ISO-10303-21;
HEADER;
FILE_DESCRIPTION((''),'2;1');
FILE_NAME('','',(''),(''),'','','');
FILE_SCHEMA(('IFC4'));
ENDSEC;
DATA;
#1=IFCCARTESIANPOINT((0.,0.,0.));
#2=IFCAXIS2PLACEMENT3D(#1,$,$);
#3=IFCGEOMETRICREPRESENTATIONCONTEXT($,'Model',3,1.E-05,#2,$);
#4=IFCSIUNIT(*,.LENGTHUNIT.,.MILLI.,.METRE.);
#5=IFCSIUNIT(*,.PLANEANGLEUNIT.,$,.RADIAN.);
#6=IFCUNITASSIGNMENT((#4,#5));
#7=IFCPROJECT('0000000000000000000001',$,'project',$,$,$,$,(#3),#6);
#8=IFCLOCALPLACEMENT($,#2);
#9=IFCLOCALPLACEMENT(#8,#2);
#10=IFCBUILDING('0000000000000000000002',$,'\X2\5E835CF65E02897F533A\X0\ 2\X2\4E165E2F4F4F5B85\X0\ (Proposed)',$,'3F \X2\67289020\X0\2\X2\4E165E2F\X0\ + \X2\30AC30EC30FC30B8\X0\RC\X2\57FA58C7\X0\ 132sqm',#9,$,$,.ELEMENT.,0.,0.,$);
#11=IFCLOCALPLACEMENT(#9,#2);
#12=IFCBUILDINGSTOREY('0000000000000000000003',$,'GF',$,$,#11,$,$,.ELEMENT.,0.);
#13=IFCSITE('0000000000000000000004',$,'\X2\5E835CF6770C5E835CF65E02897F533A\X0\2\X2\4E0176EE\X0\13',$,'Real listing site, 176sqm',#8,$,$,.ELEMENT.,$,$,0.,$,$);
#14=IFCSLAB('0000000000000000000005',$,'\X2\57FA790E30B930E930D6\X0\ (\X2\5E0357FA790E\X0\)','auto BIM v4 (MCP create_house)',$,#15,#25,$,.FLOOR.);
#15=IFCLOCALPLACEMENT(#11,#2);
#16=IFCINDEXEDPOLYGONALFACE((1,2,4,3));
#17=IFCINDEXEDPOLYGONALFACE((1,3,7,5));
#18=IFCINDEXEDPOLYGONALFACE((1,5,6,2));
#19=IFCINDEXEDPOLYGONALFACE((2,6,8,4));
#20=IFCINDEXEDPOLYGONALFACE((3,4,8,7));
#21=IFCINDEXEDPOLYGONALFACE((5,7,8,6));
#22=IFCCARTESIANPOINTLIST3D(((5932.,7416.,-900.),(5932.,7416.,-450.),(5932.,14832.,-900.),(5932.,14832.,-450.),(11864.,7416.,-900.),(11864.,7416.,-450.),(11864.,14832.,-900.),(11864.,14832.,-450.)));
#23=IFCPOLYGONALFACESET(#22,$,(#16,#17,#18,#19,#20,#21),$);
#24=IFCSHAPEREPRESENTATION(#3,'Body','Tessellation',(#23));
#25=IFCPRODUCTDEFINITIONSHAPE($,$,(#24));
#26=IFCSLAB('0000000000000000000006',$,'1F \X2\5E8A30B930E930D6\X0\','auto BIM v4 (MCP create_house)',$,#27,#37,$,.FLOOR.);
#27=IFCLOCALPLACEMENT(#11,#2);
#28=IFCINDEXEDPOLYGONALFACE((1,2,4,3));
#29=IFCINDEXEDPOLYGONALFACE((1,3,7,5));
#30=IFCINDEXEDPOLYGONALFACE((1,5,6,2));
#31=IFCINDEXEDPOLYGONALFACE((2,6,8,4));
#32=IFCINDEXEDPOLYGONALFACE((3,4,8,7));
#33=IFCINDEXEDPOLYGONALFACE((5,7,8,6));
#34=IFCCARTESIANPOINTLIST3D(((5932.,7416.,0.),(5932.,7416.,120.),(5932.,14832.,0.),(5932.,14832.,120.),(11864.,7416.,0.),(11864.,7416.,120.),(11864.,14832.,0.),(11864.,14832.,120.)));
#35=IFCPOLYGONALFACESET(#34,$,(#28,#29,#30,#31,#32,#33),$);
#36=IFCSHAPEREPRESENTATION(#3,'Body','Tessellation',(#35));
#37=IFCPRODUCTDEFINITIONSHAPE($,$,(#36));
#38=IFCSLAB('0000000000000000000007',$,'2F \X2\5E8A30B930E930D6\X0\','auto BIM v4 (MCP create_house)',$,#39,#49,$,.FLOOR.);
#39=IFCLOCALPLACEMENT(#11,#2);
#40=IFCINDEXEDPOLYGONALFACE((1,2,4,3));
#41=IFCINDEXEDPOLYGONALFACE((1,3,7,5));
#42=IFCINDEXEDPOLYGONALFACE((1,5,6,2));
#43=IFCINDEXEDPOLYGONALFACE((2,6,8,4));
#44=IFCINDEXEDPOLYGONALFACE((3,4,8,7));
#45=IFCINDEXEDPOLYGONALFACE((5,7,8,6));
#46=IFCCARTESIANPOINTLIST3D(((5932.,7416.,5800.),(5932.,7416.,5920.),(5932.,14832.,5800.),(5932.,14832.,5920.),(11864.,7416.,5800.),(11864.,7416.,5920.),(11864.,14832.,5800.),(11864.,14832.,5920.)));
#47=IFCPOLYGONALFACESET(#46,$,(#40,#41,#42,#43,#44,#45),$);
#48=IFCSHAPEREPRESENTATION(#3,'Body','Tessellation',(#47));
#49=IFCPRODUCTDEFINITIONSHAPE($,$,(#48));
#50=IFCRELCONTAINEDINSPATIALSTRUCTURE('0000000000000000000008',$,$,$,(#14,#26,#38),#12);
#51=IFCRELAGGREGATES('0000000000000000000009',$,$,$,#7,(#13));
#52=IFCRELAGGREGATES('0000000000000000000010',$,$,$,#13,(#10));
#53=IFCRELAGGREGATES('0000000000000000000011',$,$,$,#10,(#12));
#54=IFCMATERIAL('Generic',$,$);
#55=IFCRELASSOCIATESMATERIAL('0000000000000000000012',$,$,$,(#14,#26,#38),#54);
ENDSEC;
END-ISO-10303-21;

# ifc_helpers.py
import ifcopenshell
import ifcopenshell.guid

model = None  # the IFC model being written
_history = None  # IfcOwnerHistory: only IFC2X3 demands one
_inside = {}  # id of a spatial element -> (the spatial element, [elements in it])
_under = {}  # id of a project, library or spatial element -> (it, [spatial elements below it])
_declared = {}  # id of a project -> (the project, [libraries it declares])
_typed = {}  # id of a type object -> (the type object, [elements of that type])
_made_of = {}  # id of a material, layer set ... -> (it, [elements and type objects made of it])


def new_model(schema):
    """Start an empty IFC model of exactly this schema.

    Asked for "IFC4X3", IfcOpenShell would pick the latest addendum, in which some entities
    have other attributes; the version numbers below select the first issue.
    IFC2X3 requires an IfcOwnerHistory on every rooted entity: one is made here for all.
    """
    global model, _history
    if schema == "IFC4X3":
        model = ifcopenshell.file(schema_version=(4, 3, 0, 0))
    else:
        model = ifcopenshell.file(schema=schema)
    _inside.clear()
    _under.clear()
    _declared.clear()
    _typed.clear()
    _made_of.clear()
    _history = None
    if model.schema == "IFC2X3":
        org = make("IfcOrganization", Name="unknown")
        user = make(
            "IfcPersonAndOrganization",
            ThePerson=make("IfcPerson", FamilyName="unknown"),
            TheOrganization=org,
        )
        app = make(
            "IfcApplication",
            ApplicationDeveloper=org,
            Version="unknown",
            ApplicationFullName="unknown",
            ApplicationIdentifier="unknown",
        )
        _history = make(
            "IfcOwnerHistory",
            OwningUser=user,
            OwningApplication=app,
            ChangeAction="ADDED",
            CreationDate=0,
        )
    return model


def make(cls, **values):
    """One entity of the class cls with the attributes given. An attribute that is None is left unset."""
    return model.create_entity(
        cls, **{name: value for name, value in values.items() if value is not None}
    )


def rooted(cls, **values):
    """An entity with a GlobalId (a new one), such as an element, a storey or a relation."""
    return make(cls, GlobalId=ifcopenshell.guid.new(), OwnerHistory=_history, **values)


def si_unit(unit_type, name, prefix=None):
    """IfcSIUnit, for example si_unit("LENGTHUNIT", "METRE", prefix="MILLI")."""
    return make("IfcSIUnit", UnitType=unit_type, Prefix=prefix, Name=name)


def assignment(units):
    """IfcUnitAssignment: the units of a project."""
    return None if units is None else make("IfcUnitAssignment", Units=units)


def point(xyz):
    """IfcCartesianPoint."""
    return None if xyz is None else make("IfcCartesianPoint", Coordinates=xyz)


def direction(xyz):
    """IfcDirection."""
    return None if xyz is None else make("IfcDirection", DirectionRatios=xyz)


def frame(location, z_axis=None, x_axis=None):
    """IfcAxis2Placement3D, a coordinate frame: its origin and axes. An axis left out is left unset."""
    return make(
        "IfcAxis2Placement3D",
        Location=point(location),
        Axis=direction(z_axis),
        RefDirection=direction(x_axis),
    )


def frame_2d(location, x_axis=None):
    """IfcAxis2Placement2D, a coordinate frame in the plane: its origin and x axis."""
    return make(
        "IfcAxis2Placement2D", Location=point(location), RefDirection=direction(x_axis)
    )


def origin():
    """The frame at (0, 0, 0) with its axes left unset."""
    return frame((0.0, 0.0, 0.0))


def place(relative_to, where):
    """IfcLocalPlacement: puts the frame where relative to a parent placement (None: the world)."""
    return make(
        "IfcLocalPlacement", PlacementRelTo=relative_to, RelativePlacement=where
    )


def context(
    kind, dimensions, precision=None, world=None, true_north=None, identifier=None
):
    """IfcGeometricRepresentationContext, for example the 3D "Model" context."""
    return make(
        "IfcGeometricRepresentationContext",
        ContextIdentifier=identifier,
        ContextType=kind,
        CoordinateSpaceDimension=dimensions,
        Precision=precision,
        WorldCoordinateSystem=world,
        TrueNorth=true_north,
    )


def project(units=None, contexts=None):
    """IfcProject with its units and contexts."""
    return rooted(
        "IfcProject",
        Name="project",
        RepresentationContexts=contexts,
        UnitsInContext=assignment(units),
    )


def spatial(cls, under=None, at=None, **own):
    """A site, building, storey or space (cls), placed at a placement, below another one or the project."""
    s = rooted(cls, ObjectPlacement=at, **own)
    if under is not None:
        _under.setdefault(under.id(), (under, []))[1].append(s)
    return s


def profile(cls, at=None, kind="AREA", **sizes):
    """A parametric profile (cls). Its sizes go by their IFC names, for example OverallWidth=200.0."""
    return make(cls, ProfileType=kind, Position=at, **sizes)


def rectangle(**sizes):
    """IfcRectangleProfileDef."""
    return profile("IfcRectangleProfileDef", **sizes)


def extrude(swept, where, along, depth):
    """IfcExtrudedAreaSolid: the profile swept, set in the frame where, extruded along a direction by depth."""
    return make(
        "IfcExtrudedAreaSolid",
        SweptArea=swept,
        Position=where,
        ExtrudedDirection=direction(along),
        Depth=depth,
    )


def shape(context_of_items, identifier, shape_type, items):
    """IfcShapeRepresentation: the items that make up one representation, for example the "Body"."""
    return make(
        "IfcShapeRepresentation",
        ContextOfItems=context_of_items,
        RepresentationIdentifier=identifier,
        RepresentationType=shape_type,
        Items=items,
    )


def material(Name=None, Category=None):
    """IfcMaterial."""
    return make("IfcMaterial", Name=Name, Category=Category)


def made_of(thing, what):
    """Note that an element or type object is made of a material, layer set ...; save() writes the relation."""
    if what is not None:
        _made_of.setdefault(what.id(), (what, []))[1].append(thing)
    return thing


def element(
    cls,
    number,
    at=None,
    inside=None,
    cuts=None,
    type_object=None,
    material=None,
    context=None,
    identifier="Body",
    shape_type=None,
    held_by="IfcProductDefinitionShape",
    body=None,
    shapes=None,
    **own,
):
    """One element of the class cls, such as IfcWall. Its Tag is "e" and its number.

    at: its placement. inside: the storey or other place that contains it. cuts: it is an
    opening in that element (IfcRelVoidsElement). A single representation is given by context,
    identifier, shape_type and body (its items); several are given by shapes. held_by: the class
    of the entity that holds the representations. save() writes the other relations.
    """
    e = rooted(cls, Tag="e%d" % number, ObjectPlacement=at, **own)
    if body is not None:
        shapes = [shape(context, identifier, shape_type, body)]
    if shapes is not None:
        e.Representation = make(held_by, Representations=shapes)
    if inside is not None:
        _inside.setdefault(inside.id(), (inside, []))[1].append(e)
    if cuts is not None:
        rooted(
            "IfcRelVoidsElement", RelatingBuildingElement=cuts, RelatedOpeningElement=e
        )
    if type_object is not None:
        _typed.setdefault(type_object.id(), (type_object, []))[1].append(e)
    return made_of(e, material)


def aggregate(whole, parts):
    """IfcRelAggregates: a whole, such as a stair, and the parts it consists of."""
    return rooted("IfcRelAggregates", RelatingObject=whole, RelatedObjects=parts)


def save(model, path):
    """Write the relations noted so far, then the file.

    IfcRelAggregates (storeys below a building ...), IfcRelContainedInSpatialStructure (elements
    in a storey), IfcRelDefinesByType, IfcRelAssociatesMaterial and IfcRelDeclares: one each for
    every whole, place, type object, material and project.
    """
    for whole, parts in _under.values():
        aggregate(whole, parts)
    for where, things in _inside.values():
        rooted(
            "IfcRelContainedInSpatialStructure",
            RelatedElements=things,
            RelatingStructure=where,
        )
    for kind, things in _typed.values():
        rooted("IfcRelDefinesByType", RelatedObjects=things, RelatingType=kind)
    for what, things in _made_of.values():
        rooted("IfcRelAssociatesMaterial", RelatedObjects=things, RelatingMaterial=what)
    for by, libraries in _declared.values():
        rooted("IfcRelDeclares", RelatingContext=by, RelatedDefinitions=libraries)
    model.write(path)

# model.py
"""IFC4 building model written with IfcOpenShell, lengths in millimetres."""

from ifc_helpers import new_model, si_unit, frame, frame_2d, origin, place, context, project, spatial, rectangle, extrude, material, element, save


model = new_model("IFC4")

# Units and contexts
model_context = context("Model", 3, precision=1e-05, world=origin())
ifc_project = project(units=[si_unit("LENGTHUNIT", "METRE", prefix="MILLI"), si_unit("PLANEANGLEUNIT", "RADIAN")], contexts=[model_context])

# Site, building, storey
site_placement = place(None, origin())
site = spatial("IfcSite", under=ifc_project, at=site_placement, Name="広島県広島市西区2丁目13", ObjectType="Real listing site, 176sqm", CompositionType="ELEMENT", RefElevation=0.0)
building_placement = place(site_placement, origin())
building = spatial("IfcBuilding", under=site, at=building_placement, Name="広島市西区 2世帯住宅 (Proposed)", ObjectType="3F 木造2世帯 + ガレージRC基壇 132sqm", CompositionType="ELEMENT", ElevationOfRefHeight=0.0, ElevationOfTerrain=0.0)
storey_placement = place(building_placement, origin())
storey = spatial("IfcBuildingStorey", under=building, at=storey_placement, Name="GF", CompositionType="ELEMENT", Elevation=0.0)

# Slabs
ifc_material = material(Name="Generic")
slab_1_placement = place(storey_placement, frame((2966.0, 3708.0, -450.0)))
element("IfcSlab", 1, at=slab_1_placement, inside=storey, material=ifc_material, Name="基礎スラブ (布基礎)", Description="auto BIM v4 (MCP create_house)", PredefinedType="FLOOR", context=model_context, shape_type="SweptSolid", body=[
    extrude(rectangle(XDim=5932.0, YDim=7416.0, at=frame_2d((2966.0, 3708.0))), frame((2966.0, 3708.0, -450.0)), (0.0, 0.0, 1.0), 450.0),
])
slab_2_placement = place(storey_placement, frame((2966.0, 3708.0, 0.0)))
element("IfcSlab", 2, at=slab_2_placement, inside=storey, material=ifc_material, Name="1F 床スラブ", Description="auto BIM v4 (MCP create_house)", PredefinedType="FLOOR", context=model_context, shape_type="SweptSolid", body=[
    extrude(rectangle(XDim=5932.0, YDim=7416.0, at=frame_2d((2966.0, 3708.0))), frame((2966.0, 3708.0, 0.0)), (0.0, 0.0, 1.0), 120.0),
])
slab_3_placement = place(storey_placement, frame((2966.0, 3708.0, 2900.0)))
element("IfcSlab", 3, at=slab_3_placement, inside=storey, material=ifc_material, Name="2F 床スラブ", Description="auto BIM v4 (MCP create_house)", PredefinedType="FLOOR", context=model_context, shape_type="SweptSolid", body=[
    extrude(rectangle(XDim=5932.0, YDim=7416.0, at=frame_2d((2966.0, 3708.0))), frame((2966.0, 3708.0, 2900.0)), (0.0, 0.0, 1.0), 120.0),
])

save(model, "model.ifc")
